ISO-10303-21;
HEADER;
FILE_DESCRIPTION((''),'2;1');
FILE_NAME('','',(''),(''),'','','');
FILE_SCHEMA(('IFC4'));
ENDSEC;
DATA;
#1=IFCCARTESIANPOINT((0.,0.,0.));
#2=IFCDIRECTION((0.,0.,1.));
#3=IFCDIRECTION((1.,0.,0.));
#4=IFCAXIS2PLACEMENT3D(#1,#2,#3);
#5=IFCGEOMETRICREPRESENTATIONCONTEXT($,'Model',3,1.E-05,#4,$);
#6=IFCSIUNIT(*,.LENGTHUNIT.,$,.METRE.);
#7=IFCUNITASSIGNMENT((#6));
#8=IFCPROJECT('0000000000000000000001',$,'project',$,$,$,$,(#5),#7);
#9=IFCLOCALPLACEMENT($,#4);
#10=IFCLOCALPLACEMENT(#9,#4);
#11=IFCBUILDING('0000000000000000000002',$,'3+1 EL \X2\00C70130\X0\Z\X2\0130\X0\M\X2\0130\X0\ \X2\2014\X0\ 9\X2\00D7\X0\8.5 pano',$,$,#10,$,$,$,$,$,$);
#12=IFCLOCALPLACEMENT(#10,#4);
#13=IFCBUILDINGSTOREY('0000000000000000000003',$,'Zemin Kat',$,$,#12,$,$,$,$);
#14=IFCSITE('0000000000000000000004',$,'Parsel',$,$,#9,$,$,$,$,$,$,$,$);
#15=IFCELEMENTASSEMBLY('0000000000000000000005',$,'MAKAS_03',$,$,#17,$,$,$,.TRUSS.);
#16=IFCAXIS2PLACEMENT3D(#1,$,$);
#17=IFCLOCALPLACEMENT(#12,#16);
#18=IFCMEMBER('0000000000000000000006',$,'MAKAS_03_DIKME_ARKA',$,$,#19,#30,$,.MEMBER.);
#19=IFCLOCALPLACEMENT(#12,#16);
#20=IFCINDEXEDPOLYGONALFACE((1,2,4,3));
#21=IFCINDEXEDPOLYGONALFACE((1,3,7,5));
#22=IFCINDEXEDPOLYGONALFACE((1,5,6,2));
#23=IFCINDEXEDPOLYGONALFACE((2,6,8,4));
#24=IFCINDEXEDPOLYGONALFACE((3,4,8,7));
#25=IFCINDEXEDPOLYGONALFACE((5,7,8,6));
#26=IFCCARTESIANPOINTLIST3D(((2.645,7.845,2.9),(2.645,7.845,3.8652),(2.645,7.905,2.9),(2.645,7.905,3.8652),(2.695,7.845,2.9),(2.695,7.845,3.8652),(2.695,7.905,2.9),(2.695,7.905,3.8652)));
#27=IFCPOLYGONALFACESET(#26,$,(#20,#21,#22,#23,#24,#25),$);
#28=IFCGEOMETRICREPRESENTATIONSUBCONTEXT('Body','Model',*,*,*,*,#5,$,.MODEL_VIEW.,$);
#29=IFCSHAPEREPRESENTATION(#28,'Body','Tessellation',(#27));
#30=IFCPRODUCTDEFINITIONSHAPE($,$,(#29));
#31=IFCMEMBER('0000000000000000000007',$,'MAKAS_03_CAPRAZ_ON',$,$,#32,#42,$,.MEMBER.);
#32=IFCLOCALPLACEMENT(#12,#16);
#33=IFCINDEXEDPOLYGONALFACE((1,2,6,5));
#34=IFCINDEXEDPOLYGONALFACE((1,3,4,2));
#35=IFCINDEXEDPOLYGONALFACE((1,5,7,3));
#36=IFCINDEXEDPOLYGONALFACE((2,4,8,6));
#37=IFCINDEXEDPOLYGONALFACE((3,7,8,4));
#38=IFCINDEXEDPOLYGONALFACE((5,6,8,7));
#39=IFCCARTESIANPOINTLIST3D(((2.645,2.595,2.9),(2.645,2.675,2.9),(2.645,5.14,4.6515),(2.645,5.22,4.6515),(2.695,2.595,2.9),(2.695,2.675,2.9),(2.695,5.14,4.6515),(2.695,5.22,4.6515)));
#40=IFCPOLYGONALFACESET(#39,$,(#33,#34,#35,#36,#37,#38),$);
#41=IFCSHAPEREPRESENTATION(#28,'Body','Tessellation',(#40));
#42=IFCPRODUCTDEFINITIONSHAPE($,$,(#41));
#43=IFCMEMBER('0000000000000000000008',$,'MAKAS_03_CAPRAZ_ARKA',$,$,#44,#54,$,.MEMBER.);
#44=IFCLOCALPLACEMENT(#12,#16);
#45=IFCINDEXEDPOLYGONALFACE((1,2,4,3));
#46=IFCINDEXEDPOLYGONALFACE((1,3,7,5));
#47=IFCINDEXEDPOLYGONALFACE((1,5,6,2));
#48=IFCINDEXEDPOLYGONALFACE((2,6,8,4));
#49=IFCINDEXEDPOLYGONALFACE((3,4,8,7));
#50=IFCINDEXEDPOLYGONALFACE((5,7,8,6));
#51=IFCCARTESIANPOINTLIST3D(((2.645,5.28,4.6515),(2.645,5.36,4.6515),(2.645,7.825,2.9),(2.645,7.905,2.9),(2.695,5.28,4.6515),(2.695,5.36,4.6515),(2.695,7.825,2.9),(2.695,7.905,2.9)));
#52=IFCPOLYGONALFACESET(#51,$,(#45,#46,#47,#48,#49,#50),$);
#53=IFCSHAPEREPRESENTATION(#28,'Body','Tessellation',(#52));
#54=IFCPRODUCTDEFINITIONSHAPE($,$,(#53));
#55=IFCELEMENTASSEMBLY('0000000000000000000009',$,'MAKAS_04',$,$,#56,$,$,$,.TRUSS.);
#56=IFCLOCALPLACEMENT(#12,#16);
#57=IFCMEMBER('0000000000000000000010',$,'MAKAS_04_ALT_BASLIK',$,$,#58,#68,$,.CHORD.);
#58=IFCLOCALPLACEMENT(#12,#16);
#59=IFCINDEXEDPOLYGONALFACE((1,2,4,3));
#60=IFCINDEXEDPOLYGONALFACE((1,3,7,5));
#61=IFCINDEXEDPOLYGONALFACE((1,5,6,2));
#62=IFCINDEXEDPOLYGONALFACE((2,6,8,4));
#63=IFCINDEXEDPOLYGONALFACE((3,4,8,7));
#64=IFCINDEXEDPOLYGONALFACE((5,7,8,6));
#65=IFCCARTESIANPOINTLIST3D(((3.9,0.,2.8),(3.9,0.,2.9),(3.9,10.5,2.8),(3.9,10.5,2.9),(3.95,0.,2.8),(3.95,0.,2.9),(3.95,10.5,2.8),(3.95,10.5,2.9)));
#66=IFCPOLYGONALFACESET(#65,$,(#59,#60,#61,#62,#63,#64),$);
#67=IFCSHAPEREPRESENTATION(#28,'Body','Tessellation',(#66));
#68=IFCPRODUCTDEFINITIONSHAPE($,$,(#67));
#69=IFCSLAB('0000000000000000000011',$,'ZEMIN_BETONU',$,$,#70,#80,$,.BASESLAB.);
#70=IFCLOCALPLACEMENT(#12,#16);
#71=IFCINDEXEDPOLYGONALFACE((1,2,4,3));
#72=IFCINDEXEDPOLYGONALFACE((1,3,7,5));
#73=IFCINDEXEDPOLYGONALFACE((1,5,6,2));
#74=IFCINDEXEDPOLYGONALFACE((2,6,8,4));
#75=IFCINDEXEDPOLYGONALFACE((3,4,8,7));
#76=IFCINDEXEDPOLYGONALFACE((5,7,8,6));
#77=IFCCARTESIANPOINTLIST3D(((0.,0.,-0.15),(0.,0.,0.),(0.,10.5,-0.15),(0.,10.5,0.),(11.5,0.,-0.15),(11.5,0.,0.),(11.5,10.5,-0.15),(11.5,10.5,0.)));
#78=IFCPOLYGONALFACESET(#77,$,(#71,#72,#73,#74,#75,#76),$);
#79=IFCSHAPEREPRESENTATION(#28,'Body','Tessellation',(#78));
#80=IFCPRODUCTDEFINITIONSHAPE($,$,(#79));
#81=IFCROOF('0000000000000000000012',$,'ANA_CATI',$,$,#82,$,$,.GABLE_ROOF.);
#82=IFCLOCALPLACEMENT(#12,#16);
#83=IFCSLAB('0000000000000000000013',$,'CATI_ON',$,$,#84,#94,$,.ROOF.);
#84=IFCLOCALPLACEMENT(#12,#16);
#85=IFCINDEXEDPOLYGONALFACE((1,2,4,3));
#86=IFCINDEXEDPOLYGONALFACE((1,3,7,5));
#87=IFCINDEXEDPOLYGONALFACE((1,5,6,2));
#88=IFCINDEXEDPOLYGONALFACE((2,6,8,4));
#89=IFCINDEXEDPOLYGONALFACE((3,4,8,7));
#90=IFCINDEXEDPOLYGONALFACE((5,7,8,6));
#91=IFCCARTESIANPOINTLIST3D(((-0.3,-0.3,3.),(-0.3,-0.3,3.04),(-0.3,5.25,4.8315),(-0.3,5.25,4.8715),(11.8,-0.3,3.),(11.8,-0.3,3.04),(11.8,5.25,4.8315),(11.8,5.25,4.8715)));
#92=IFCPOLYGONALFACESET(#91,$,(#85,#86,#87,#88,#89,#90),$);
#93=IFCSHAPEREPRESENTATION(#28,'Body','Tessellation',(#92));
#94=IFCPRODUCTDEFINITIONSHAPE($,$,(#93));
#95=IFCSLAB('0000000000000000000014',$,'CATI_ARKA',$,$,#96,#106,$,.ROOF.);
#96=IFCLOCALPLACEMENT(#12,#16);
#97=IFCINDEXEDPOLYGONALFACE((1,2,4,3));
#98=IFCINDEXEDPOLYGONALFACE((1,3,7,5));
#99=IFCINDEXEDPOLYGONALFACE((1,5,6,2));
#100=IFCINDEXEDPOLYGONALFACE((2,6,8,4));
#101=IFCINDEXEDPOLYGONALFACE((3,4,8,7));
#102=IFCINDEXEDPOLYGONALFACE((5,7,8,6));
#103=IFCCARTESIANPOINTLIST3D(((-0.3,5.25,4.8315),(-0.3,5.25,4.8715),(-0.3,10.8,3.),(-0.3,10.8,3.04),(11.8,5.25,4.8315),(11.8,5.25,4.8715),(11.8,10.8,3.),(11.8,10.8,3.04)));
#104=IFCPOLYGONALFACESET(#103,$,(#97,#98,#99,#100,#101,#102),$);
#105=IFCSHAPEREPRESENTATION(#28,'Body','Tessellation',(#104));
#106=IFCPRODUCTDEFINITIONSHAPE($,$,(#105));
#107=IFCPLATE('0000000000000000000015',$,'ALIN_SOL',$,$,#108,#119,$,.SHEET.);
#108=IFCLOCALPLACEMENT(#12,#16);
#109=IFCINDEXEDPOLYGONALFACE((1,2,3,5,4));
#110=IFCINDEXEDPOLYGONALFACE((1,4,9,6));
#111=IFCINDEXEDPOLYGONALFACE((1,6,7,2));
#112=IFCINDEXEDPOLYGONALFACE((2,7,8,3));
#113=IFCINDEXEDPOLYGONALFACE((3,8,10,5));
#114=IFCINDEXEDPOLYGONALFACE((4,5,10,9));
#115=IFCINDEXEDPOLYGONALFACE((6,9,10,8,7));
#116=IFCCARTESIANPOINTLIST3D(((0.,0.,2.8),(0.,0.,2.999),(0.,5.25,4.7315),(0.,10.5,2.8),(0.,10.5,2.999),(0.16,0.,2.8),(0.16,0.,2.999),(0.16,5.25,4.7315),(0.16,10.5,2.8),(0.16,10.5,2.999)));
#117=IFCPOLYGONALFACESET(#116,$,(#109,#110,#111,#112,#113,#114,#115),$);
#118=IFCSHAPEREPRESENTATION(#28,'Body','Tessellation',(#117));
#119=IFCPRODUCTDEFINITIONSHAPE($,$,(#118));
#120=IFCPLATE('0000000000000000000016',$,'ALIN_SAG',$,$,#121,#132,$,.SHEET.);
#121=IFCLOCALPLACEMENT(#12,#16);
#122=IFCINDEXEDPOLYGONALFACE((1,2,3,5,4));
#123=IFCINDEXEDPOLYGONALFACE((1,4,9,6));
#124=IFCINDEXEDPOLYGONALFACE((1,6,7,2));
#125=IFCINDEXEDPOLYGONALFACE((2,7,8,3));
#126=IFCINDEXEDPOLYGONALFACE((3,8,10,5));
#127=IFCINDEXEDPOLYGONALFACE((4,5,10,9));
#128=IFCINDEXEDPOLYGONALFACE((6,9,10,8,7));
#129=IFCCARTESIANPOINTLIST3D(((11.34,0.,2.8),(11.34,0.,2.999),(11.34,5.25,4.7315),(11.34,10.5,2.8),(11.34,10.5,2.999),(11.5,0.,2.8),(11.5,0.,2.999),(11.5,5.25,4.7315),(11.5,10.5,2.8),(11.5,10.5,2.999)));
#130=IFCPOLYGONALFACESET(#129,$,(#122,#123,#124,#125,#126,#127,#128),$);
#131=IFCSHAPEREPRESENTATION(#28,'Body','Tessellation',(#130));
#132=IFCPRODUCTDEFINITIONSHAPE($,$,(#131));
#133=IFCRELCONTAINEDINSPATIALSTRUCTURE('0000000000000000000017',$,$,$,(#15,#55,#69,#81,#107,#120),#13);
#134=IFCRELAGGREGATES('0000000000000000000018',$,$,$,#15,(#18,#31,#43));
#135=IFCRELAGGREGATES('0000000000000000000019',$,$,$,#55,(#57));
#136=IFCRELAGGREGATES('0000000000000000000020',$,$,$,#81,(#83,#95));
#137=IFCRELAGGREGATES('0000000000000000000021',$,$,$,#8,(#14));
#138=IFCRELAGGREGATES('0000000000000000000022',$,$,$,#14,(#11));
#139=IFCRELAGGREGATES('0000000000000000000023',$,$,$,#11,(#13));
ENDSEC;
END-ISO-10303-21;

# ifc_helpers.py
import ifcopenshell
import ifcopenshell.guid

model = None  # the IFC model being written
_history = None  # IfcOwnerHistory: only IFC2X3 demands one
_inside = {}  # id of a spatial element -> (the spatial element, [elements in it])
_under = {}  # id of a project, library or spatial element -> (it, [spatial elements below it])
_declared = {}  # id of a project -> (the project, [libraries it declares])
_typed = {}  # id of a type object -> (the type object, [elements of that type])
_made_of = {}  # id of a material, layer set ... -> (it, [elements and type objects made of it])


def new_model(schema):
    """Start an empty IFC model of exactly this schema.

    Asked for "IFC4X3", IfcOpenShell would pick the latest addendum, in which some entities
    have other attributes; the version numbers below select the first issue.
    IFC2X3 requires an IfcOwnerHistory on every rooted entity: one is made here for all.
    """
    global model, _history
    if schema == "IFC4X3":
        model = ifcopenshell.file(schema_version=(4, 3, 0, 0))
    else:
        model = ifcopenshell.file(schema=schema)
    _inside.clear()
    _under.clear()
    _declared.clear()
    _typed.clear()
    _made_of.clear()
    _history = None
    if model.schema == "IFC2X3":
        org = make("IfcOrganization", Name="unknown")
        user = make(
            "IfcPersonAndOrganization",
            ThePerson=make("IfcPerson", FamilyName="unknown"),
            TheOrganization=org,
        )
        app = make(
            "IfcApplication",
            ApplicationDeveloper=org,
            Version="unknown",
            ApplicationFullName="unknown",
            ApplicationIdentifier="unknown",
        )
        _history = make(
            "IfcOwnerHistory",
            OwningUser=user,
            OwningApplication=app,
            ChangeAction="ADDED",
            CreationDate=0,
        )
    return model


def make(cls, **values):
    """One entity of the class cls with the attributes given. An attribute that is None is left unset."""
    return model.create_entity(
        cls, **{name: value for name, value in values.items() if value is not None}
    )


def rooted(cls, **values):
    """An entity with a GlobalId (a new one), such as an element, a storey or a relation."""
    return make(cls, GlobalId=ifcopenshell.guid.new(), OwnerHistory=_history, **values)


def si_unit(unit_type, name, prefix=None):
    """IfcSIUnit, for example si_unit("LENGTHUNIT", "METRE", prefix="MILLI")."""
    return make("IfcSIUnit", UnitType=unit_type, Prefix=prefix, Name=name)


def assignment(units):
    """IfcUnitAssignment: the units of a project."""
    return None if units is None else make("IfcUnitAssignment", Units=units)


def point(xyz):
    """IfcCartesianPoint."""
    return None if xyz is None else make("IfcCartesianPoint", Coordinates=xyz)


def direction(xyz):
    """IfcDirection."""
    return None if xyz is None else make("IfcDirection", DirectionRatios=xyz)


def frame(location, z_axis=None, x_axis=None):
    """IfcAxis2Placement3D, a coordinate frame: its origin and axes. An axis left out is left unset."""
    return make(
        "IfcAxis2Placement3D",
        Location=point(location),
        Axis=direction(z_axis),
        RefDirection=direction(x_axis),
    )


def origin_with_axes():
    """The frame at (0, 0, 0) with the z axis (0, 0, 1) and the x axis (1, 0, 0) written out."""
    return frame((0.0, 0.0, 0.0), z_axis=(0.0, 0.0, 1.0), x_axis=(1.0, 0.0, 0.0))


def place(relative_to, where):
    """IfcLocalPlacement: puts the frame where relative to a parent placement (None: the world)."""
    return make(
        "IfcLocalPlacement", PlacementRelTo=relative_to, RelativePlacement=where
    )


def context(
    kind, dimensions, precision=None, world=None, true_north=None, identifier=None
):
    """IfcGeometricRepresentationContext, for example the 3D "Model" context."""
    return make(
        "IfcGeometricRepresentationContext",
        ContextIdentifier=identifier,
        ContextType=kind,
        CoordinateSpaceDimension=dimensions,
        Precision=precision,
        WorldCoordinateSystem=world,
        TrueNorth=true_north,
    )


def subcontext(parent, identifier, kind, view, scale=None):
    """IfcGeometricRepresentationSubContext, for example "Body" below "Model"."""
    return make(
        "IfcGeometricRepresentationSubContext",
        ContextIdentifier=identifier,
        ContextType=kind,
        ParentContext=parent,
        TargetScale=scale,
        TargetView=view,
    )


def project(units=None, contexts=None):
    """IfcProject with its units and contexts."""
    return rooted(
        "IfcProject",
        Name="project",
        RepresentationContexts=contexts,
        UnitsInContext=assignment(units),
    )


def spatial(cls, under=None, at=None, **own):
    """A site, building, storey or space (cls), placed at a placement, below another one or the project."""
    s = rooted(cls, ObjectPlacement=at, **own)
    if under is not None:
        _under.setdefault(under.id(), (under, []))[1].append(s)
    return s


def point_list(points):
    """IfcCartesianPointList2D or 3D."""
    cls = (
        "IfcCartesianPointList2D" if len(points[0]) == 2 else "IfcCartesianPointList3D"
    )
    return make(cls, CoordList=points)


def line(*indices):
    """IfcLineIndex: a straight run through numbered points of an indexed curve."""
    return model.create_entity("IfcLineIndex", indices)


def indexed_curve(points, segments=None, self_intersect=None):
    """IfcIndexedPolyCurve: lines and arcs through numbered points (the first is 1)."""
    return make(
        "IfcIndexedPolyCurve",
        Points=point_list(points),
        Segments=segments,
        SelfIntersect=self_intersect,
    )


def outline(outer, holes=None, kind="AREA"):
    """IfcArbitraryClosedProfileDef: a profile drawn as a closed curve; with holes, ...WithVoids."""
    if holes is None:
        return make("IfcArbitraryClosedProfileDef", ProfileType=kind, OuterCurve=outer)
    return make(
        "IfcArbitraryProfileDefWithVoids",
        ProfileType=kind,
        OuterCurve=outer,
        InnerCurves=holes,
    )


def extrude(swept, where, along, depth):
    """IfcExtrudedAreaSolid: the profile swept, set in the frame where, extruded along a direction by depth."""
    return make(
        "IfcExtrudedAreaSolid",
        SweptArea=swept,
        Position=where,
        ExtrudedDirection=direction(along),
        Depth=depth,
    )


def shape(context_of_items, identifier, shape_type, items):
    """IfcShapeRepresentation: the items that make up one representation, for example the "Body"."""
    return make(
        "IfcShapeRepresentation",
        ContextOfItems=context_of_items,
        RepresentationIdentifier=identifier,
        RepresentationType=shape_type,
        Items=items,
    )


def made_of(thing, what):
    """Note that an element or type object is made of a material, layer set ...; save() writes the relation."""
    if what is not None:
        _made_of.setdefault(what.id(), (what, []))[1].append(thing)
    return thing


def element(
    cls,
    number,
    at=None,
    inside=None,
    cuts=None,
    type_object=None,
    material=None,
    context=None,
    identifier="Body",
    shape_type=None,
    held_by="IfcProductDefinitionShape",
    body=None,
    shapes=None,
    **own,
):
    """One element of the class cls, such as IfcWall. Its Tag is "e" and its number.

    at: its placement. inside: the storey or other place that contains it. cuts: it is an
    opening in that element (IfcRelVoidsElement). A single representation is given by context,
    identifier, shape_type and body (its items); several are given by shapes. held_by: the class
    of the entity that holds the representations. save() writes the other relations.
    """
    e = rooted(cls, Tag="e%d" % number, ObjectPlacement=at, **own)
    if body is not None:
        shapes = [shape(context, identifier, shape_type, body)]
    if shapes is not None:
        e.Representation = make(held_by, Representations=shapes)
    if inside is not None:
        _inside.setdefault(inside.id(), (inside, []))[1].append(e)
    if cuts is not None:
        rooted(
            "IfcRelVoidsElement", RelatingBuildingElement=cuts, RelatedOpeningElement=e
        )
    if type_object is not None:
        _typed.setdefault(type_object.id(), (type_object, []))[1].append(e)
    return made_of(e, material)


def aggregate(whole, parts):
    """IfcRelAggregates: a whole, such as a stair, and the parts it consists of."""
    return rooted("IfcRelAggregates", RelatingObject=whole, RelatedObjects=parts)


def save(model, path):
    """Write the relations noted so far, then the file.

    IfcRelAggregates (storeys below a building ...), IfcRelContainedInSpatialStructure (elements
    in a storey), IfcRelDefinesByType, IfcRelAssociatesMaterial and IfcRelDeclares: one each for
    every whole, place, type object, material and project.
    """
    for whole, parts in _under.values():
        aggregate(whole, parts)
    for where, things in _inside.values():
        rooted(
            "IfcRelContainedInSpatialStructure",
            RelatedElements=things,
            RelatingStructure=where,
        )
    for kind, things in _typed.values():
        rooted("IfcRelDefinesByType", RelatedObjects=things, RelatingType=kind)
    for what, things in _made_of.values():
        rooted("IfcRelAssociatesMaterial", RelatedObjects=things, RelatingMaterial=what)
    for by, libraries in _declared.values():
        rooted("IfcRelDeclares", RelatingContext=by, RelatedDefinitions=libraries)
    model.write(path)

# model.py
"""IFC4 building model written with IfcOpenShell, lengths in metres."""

from ifc_helpers import new_model, si_unit, frame, origin_with_axes, place, context, subcontext, project, spatial, line, indexed_curve, outline, extrude, element, aggregate, save


model = new_model("IFC4")

# Units and contexts
model_context = context("Model", 3, precision=1e-05, world=origin_with_axes())
body_context = subcontext(model_context, "Body", "Model", "MODEL_VIEW")
ifc_project = project(units=[si_unit("LENGTHUNIT", "METRE")], contexts=[model_context])

# Site, building, storey
site_placement = place(None, origin_with_axes())
site = spatial("IfcSite", under=ifc_project, at=site_placement, Name="Parsel")
building_placement = place(site_placement, origin_with_axes())
building = spatial("IfcBuilding", under=site, at=building_placement, Name="3+1 EL ÇİZİMİ — 9×8.5 pano")
storey_placement = place(building_placement, origin_with_axes())
storey = spatial("IfcBuildingStorey", under=building, at=storey_placement, Name="Zemin Kat")

# Element assembly, members
assembly_1_placement = place(storey_placement, origin_with_axes())
assembly_1 = element("IfcElementAssembly", 1, at=assembly_1_placement, inside=storey, Name="MAKAS_03", PredefinedType="TRUSS")
member_1_placement = place(assembly_1_placement, origin_with_axes())
member_1 = element("IfcMember", 2, at=member_1_placement, Name="MAKAS_03_DIKME_ARKA", PredefinedType="MEMBER", context=body_context, shape_type="SweptSolid", body=[
    extrude(outline(indexed_curve([(7.845, 2.9), (7.905, 2.9), (7.905, 3.8653), (7.845, 3.8653)], segments=[line(1, 2, 3, 4, 1)])), frame((2.645, 0.0, 0.0), z_axis=(1.0, 0.0, 0.0), x_axis=(0.0, 1.0, 0.0)), (0.0, 0.0, 1.0), 0.05),
])
member_2_placement = place(assembly_1_placement, origin_with_axes())
member_2 = element("IfcMember", 3, at=member_2_placement, Name="MAKAS_03_CAPRAZ_ON", PredefinedType="MEMBER", context=body_context, shape_type="SweptSolid", body=[
    extrude(outline(indexed_curve([(2.595, 2.9), (2.675, 2.9), (5.22, 4.6515), (5.14, 4.6515)], segments=[line(1, 2, 3, 4, 1)])), frame((2.645, 0.0, 0.0), z_axis=(1.0, 0.0, 0.0), x_axis=(0.0, 1.0, 0.0)), (0.0, 0.0, 1.0), 0.05),
])
member_3_placement = place(assembly_1_placement, origin_with_axes())
member_3 = element("IfcMember", 4, at=member_3_placement, Name="MAKAS_03_CAPRAZ_ARKA", PredefinedType="MEMBER", context=body_context, shape_type="SweptSolid", body=[
    extrude(outline(indexed_curve([(7.825, 2.9), (7.905, 2.9), (5.36, 4.6515), (5.28, 4.6515)], segments=[line(1, 2, 3, 4, 1)])), frame((2.645, 0.0, 0.0), z_axis=(1.0, 0.0, 0.0), x_axis=(0.0, 1.0, 0.0)), (0.0, 0.0, 1.0), 0.05),
])
aggregate(assembly_1, [member_1, member_2, member_3])

# Element assembly, member
assembly_2_placement = place(storey_placement, origin_with_axes())
assembly_2 = element("IfcElementAssembly", 5, at=assembly_2_placement, inside=storey, Name="MAKAS_04", PredefinedType="TRUSS")
member_4_placement = place(assembly_2_placement, origin_with_axes())
member_4 = element("IfcMember", 6, at=member_4_placement, Name="MAKAS_04_ALT_BASLIK", PredefinedType="CHORD", context=body_context, shape_type="SweptSolid", body=[
    extrude(outline(indexed_curve([(0.0, 2.8), (10.5, 2.8), (10.5, 2.9), (0.0, 2.9)], segments=[line(1, 2, 3, 4, 1)])), frame((3.9, 0.0, 0.0), z_axis=(1.0, 0.0, 0.0), x_axis=(0.0, 1.0, 0.0)), (0.0, 0.0, 1.0), 0.05),
])
aggregate(assembly_2, [member_4])

# Slab
slab_1_placement = place(storey_placement, origin_with_axes())
element("IfcSlab", 7, at=slab_1_placement, inside=storey, Name="ZEMIN_BETONU", PredefinedType="BASESLAB", context=body_context, shape_type="SweptSolid", body=[
    extrude(outline(indexed_curve([(0.0, 0.0), (11.5, 0.0), (11.5, 10.5), (0.0, 10.5)], segments=[line(1, 2, 3, 4, 1)])), frame((0.0, 0.0, -0.15), z_axis=(0.0, 0.0, 1.0), x_axis=(1.0, 0.0, 0.0)), (0.0, 0.0, 1.0), 0.15),
])

# Roof, slabs
roof_placement = place(storey_placement, origin_with_axes())
roof = element("IfcRoof", 8, at=roof_placement, inside=storey, Name="ANA_CATI", PredefinedType="GABLE_ROOF")
slab_2_placement = place(roof_placement, origin_with_axes())
slab_2 = element("IfcSlab", 9, at=slab_2_placement, Name="CATI_ON", PredefinedType="ROOF", context=body_context, shape_type="SweptSolid", body=[
    extrude(outline(indexed_curve([(-0.3, 3.0), (5.25, 4.8315), (5.25, 4.8715), (-0.3, 3.04)], segments=[line(1, 2, 3, 4, 1)])), frame((-0.3, 0.0, 0.0), z_axis=(1.0, 0.0, 0.0), x_axis=(0.0, 1.0, 0.0)), (0.0, 0.0, 1.0), 12.1),
])
slab_3_placement = place(roof_placement, origin_with_axes())
slab_3 = element("IfcSlab", 10, at=slab_3_placement, Name="CATI_ARKA", PredefinedType="ROOF", context=body_context, shape_type="SweptSolid", body=[
    extrude(outline(indexed_curve([(5.25, 4.8315), (10.8, 3.0), (10.8, 3.04), (5.25, 4.8715)], segments=[line(1, 2, 3, 4, 1)])), frame((-0.3, 0.0, 0.0), z_axis=(1.0, 0.0, 0.0), x_axis=(0.0, 1.0, 0.0)), (0.0, 0.0, 1.0), 12.1),
])
aggregate(roof, [slab_2, slab_3])

# Plates
plate_1_placement = place(storey_placement, origin_with_axes())
element("IfcPlate", 11, at=plate_1_placement, inside=storey, Name="ALIN_SOL", PredefinedType="SHEET", context=body_context, shape_type="SweptSolid", body=[
    extrude(outline(indexed_curve([(0.0, 2.8), (10.5, 2.8), (10.5, 2.999), (5.25, 4.7315), (0.0, 2.999)], segments=[line(1, 2, 3, 4, 5, 1)])), frame((0.0, 0.0, 0.0), z_axis=(1.0, 0.0, 0.0), x_axis=(0.0, 1.0, 0.0)), (0.0, 0.0, 1.0), 0.16),
])
plate_2_placement = place(storey_placement, origin_with_axes())
element("IfcPlate", 12, at=plate_2_placement, inside=storey, Name="ALIN_SAG", PredefinedType="SHEET", context=body_context, shape_type="SweptSolid", body=[
    extrude(outline(indexed_curve([(0.0, 2.8), (10.5, 2.8), (10.5, 2.999), (5.25, 4.7315), (0.0, 2.999)], segments=[line(1, 2, 3, 4, 5, 1)])), frame((11.34, 0.0, 0.0), z_axis=(1.0, 0.0, 0.0), x_axis=(0.0, 1.0, 0.0)), (0.0, 0.0, 1.0), 0.16),
])

save(model, "model.ifc")
